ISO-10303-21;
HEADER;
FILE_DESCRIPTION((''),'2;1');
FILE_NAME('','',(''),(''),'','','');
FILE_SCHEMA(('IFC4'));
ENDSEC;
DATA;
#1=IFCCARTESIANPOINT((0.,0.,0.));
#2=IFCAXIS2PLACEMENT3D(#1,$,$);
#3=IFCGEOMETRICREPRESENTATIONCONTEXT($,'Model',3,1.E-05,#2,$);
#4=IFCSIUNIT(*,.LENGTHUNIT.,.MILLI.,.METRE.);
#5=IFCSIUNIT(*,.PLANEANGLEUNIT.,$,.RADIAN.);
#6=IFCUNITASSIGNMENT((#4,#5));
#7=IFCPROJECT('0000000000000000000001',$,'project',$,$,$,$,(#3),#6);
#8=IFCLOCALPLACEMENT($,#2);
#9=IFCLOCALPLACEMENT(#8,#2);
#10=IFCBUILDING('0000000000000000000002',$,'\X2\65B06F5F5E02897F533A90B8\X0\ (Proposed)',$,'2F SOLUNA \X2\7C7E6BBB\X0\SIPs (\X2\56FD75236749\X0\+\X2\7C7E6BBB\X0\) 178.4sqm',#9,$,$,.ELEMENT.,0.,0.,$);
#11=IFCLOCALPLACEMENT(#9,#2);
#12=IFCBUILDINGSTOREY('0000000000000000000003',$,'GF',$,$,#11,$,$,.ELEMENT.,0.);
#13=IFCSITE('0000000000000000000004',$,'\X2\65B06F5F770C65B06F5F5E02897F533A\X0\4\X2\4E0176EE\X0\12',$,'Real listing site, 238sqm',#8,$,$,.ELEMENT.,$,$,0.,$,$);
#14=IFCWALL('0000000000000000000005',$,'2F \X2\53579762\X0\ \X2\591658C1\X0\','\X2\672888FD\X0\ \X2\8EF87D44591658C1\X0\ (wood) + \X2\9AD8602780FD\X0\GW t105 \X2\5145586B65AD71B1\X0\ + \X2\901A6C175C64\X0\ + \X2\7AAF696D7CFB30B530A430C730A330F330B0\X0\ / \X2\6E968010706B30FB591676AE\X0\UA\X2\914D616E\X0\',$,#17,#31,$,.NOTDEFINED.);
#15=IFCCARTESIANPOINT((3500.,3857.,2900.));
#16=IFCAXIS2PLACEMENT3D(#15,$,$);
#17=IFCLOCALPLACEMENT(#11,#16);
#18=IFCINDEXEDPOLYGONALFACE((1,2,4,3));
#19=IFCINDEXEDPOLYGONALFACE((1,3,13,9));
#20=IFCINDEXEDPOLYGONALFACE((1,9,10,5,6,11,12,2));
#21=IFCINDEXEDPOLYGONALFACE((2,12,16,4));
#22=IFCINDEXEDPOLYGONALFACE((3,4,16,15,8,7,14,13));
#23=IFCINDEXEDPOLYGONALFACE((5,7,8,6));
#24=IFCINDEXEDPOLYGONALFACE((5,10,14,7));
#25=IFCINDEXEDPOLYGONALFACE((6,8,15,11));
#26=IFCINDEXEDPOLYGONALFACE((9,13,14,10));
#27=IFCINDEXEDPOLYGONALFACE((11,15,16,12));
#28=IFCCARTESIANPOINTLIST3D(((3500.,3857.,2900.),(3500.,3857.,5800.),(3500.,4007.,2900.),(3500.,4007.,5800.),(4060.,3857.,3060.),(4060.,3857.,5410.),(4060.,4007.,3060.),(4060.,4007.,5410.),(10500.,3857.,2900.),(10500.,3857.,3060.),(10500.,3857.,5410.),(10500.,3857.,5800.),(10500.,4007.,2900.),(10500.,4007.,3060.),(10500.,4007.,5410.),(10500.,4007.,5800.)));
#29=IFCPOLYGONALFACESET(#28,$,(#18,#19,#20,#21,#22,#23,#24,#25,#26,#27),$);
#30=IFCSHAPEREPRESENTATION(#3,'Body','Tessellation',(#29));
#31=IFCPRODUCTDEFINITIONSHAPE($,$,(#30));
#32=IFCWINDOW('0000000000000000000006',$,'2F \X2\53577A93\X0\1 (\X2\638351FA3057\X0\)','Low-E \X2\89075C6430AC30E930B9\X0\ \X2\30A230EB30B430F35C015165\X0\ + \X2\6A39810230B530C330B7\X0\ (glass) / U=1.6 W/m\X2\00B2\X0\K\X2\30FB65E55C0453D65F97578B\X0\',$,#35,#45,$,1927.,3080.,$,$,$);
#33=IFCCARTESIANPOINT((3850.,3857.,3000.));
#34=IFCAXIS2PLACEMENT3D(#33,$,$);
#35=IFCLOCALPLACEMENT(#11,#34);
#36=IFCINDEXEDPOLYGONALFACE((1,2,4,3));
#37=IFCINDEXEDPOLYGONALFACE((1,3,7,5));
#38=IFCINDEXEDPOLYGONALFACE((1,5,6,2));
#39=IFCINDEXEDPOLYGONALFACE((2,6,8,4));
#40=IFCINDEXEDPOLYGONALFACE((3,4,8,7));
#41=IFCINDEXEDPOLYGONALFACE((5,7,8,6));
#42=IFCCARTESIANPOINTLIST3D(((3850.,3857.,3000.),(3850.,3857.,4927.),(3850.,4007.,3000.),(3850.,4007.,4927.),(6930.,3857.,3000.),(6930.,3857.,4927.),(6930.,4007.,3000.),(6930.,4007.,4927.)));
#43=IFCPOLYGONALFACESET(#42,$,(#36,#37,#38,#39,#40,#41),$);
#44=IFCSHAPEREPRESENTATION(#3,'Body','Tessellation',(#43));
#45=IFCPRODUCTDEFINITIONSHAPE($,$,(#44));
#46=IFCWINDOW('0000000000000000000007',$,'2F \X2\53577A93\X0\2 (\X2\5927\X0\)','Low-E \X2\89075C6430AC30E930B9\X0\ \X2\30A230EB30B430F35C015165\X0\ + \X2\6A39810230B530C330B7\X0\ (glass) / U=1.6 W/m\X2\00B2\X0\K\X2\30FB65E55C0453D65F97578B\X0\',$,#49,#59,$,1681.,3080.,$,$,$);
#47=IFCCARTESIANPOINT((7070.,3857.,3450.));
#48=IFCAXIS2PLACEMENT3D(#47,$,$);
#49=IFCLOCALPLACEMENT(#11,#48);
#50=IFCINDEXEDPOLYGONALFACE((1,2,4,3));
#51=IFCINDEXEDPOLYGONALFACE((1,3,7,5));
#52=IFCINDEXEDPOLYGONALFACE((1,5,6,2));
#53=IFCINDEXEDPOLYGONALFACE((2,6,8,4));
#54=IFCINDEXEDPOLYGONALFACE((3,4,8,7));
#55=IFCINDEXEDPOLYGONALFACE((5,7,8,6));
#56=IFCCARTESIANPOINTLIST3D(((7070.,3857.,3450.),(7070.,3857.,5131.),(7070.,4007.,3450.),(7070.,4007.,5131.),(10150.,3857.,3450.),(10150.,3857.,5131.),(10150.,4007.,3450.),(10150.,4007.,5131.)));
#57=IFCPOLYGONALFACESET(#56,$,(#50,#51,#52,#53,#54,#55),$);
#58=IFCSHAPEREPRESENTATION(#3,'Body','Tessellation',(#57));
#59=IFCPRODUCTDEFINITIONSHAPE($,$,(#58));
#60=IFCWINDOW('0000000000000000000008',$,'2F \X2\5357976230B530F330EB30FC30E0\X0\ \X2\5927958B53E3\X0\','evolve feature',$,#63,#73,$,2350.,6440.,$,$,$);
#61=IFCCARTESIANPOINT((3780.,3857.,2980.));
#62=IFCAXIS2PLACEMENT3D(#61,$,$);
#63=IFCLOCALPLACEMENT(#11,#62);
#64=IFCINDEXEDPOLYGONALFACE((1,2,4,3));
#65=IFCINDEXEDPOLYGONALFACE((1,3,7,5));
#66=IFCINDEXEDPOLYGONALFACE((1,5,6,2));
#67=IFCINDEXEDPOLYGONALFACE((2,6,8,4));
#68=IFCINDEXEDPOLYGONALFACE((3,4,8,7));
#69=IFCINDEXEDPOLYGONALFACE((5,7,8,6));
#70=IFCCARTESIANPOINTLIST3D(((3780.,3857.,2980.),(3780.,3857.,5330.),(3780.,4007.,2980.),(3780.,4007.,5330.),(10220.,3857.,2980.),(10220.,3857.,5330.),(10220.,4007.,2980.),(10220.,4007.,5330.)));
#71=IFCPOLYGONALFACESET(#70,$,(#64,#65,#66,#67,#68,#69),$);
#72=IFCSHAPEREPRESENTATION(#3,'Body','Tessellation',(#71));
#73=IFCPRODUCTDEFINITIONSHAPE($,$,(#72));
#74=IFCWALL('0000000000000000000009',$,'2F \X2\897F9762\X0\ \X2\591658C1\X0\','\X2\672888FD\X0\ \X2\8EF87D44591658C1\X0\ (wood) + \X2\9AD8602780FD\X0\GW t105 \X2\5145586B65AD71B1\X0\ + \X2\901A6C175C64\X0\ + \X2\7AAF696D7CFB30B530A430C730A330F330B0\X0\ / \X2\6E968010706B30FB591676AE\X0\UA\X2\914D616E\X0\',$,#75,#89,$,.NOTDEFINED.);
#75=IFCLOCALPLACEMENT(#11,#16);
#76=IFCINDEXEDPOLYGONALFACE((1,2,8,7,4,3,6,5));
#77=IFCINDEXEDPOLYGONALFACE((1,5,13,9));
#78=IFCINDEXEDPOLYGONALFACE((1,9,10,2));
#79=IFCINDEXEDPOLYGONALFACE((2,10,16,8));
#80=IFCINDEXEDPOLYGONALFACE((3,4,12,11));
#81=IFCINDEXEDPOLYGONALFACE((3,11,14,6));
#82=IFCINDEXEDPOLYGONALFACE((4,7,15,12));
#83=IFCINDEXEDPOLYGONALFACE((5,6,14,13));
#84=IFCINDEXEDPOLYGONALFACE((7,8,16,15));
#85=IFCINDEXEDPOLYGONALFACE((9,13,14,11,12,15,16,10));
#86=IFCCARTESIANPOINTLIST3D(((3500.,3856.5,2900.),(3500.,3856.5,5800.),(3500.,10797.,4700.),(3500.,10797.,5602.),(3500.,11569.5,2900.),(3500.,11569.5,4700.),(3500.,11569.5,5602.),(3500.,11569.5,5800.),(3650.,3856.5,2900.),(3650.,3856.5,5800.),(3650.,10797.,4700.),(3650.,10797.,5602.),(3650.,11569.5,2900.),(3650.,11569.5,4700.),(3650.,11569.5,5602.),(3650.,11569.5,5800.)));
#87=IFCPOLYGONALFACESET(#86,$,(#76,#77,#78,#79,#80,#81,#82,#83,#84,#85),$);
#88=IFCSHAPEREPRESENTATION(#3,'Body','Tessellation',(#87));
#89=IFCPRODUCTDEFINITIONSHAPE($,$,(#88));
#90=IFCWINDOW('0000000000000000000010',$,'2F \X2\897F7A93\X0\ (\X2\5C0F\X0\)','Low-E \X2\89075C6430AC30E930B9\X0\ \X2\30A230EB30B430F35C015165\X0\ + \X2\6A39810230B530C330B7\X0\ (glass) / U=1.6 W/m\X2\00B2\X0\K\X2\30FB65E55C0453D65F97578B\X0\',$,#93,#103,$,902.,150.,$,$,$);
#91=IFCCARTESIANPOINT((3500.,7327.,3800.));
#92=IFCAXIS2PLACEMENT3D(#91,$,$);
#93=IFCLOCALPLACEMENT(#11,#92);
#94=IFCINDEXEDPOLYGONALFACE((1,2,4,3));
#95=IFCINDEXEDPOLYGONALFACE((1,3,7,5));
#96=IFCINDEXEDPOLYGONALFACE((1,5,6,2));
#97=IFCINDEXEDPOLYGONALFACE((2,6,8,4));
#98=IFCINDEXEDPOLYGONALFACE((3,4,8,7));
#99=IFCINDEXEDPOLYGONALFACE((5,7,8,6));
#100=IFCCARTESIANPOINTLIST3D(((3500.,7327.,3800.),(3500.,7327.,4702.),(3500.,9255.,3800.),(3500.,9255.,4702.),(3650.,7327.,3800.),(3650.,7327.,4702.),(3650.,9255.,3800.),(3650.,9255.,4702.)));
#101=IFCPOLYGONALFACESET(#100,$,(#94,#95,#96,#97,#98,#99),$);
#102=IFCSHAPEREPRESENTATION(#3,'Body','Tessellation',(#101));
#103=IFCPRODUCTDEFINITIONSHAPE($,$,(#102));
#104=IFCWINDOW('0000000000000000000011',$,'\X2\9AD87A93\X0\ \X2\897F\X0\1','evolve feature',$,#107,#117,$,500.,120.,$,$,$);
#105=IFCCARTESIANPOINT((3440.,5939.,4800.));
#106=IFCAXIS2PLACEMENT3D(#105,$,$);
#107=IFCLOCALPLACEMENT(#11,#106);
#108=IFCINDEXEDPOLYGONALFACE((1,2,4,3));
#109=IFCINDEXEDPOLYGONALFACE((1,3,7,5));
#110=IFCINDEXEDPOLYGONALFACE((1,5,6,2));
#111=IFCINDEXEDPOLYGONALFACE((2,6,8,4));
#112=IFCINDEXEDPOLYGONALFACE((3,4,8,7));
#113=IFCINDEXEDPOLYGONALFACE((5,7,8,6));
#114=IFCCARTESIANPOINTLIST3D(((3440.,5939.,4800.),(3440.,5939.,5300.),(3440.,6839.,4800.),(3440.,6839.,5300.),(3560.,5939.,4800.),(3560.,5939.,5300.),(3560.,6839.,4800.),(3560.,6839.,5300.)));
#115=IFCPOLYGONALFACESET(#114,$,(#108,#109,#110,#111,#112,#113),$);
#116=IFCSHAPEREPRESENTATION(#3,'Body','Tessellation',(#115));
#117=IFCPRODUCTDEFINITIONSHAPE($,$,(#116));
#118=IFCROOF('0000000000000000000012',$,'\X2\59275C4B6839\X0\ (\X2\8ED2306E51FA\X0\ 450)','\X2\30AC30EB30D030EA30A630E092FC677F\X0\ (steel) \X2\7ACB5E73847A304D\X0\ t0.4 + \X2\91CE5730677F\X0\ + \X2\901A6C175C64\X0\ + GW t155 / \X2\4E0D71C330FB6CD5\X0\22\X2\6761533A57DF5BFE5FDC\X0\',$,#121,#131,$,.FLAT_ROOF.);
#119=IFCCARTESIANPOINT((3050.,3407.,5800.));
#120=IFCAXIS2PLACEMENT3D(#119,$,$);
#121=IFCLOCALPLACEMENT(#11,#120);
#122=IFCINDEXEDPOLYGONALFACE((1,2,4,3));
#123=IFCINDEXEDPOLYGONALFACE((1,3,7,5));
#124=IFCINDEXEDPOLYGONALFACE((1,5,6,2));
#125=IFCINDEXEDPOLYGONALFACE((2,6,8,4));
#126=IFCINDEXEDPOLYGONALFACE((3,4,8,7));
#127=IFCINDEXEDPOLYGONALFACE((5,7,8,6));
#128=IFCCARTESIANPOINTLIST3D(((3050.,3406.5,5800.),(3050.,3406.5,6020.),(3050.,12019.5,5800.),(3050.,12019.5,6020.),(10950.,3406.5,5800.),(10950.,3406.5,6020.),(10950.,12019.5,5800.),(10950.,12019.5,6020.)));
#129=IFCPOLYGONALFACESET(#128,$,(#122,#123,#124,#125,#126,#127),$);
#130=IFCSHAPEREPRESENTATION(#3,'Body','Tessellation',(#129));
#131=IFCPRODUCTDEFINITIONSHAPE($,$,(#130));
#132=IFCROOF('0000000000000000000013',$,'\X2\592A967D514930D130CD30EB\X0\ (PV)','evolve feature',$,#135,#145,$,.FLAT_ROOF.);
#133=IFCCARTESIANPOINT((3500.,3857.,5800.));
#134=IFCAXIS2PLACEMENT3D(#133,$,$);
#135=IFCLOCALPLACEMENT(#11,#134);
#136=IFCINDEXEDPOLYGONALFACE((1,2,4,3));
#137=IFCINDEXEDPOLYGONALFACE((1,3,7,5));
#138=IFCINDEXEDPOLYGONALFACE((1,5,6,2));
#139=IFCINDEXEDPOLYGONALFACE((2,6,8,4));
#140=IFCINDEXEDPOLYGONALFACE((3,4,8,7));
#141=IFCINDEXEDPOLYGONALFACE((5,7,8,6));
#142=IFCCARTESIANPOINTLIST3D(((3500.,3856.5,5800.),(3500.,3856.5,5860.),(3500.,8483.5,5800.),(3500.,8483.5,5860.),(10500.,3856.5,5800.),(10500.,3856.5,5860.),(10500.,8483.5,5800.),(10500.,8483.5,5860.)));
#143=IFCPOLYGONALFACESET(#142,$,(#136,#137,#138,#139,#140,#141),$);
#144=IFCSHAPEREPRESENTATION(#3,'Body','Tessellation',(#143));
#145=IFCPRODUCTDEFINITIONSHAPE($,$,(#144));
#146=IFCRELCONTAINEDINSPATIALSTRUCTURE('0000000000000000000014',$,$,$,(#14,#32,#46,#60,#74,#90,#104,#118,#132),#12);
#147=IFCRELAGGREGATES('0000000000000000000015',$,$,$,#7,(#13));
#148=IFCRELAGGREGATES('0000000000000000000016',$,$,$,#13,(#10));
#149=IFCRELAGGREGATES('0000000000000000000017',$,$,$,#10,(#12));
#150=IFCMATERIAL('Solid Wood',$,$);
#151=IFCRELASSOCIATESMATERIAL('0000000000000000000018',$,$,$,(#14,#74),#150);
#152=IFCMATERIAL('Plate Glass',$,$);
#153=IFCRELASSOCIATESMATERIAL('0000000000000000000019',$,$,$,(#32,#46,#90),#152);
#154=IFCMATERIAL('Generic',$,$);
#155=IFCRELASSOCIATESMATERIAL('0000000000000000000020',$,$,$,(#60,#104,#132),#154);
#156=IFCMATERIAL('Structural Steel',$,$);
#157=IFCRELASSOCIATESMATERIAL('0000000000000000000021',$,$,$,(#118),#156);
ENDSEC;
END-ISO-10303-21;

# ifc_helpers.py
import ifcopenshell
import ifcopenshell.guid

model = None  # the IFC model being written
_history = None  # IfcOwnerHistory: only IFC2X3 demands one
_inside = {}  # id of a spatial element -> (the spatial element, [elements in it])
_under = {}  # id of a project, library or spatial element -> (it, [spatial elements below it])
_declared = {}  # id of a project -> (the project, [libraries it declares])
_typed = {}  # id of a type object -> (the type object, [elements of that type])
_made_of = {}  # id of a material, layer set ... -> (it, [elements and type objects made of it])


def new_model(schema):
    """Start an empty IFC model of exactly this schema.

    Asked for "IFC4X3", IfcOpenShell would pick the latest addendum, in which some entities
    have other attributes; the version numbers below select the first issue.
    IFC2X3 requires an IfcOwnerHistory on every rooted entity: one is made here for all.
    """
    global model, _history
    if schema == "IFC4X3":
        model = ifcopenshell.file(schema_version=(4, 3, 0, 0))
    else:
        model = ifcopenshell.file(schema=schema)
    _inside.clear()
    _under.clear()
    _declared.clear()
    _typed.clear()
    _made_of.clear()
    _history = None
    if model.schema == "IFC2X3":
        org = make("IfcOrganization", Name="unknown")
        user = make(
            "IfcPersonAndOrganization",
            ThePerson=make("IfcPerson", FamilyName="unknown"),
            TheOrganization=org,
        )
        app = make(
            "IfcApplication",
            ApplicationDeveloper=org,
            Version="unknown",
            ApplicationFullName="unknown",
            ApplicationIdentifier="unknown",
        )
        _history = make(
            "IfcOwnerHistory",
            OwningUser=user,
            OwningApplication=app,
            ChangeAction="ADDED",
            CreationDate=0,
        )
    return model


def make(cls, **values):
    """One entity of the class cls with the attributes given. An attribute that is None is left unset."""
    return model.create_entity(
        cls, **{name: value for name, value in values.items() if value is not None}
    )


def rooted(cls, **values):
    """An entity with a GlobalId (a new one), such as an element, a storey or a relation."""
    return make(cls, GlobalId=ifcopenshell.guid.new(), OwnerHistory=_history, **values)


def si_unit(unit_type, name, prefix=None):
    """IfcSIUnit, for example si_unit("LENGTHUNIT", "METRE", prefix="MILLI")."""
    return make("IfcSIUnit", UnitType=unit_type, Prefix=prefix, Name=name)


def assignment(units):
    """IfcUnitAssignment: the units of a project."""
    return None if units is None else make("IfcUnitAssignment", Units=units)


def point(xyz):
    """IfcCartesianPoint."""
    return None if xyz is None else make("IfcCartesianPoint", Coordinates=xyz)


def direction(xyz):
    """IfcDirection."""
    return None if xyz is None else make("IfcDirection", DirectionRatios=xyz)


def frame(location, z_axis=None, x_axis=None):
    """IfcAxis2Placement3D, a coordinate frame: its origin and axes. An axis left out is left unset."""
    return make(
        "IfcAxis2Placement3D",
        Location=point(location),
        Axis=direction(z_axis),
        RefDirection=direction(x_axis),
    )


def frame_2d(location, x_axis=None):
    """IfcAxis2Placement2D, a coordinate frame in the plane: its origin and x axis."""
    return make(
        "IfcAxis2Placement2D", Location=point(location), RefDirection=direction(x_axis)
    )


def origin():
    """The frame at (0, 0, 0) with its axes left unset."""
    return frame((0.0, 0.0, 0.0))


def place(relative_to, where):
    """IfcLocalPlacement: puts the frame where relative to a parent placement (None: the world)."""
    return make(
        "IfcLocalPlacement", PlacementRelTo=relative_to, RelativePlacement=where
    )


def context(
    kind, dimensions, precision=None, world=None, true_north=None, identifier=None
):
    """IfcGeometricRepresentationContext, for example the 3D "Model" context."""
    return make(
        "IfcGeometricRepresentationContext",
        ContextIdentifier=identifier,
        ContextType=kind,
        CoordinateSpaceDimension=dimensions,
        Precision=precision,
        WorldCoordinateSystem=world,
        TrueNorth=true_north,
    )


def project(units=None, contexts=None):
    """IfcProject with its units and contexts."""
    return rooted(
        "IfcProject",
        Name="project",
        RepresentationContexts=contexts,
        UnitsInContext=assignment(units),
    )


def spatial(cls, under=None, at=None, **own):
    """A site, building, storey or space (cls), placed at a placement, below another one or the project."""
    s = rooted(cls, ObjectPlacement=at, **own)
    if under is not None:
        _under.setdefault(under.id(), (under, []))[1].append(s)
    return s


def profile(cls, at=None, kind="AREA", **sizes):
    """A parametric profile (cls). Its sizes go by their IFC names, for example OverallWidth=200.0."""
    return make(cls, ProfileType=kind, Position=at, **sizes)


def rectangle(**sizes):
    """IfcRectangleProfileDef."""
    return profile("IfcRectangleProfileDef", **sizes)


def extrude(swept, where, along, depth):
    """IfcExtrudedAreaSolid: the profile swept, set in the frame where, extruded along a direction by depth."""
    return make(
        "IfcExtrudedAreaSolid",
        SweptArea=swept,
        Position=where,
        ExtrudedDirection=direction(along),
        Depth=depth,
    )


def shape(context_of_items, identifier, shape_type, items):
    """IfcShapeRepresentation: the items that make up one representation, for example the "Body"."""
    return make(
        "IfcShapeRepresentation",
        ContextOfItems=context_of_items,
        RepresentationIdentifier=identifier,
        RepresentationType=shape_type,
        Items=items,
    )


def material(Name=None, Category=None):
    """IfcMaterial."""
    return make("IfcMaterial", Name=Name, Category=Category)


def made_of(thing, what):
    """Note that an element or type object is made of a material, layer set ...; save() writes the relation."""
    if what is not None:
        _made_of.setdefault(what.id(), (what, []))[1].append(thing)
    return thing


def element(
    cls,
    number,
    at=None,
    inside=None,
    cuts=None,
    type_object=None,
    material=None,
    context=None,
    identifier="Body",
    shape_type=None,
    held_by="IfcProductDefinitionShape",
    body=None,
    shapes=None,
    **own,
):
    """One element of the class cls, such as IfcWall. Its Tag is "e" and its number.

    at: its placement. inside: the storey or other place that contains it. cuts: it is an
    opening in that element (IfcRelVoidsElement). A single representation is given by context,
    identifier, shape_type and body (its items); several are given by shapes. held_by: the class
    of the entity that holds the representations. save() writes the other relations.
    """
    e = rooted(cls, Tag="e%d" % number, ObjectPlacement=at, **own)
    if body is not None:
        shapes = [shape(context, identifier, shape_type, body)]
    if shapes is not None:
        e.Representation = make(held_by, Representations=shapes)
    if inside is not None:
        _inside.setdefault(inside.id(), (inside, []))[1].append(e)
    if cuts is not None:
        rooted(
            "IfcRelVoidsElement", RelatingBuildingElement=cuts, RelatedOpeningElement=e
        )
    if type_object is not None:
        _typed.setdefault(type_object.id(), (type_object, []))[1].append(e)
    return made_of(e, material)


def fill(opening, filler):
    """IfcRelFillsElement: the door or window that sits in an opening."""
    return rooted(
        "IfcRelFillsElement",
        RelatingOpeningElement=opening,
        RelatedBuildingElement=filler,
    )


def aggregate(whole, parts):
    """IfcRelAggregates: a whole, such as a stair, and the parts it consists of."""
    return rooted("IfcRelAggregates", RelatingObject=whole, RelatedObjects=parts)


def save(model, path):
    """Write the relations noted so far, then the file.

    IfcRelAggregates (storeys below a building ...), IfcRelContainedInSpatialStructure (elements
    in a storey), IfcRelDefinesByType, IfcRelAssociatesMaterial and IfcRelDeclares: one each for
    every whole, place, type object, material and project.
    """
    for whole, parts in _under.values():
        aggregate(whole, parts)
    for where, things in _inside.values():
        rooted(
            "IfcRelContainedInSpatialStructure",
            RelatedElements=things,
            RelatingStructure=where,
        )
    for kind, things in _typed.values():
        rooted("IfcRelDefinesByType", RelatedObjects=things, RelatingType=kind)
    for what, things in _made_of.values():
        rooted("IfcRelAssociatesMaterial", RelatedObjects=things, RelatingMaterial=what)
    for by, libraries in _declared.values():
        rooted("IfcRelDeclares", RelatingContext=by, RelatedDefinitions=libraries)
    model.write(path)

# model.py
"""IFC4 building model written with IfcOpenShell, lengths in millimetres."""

from ifc_helpers import new_model, si_unit, frame, frame_2d, origin, place, context, project, spatial, rectangle, extrude, material, element, fill, save


model = new_model("IFC4")

# Units and contexts
model_context = context("Model", 3, precision=1e-05, world=origin())
ifc_project = project(units=[si_unit("LENGTHUNIT", "METRE", prefix="MILLI"), si_unit("PLANEANGLEUNIT", "RADIAN")], contexts=[model_context])

# Site, building, storey
site_placement = place(None, origin())
site = spatial("IfcSite", under=ifc_project, at=site_placement, Name="新潟県新潟市西区4丁目12", ObjectType="Real listing site, 238sqm", CompositionType="ELEMENT", RefElevation=0.0)
building_placement = place(site_placement, origin())
building = spatial("IfcBuilding", under=site, at=building_placement, Name="新潟市西区邸 (Proposed)", ObjectType="2F SOLUNA 籾殻SIPs (国産杉+籾殻) 178.4sqm", CompositionType="ELEMENT", ElevationOfRefHeight=0.0, ElevationOfTerrain=0.0)
storey_placement = place(building_placement, origin())
storey = spatial("IfcBuildingStorey", under=building, at=storey_placement, Name="GF", CompositionType="ELEMENT", Elevation=0.0)

# Shared definitions
ifc_material_1 = material(Name="Solid Wood")
ifc_material_2 = material(Name="Generic")

# Shared definitions
ifc_material_3 = material(Name="Plate Glass")

# Walls, openings, windows
wall_1_placement = place(storey_placement, frame((3500.0, 3857.0, 2900.0)))
wall_1 = element("IfcWall", 1, at=wall_1_placement, inside=storey, material=ifc_material_1, Name="2F 南面 外壁", Description="木製 軸組外壁 (wood) + 高性能GW t105 充填断熱 + 通気層 + 窯業系サイディング / 準耐火・外皮UA配慮", PredefinedType="NOTDEFINED", context=model_context, shape_type="SweptSolid", body=[
    extrude(rectangle(XDim=7000.0, YDim=150.0, at=frame_2d((3500.0, 75.0))), frame((3500.0, 3857.0, 2900.0)), (0.0, 0.0, 1.0), 2900.0),
])
opening_1_placement = place(storey_placement, frame((3850.0, 3857.0, 3000.0)))
opening_1 = element("IfcOpeningElement", 2, at=opening_1_placement, cuts=wall_1, PredefinedType="NOTDEFINED", context=model_context, shape_type="SweptSolid", body=[
    extrude(rectangle(XDim=3080.0, YDim=150.0, at=frame_2d((1540.0, 75.0))), frame((3850.0, 3857.0, 3000.0)), (0.0, 0.0, 1.0), 1927.0),
])
opening_2_placement = place(storey_placement, frame((7070.0, 3857.0, 3450.0)))
opening_2 = element("IfcOpeningElement", 3, at=opening_2_placement, cuts=wall_1, PredefinedType="NOTDEFINED", context=model_context, shape_type="SweptSolid", body=[
    extrude(rectangle(XDim=3080.0, YDim=150.0, at=frame_2d((1540.0, 75.0))), frame((7070.0, 3857.0, 3450.0)), (0.0, 0.0, 1.0), 1681.0),
])
opening_3_placement = place(storey_placement, frame((3780.0, 3857.0, 2980.0)))
opening_3 = element("IfcOpeningElement", 4, at=opening_3_placement, cuts=wall_1, PredefinedType="NOTDEFINED", context=model_context, shape_type="SweptSolid", body=[
    extrude(rectangle(XDim=6440.0, YDim=150.0, at=frame_2d((3220.0, 75.0))), frame((3780.0, 3857.0, 2980.0)), (0.0, 0.0, 1.0), 2350.0),
])
window_1_placement = place(storey_placement, frame((3850.0, 3857.0, 3000.0)))
window_1 = element("IfcWindow", 5, at=window_1_placement, inside=storey, material=ifc_material_3, Name="2F 南窓1 (掃出し)", Description="Low-E 複層ガラス アルゴン封入 + 樹脂サッシ (glass) / U=1.6 W/m²K・日射取得型", OverallHeight=1927.0, OverallWidth=3080.0, context=model_context, shape_type="SweptSolid", body=[
    extrude(rectangle(XDim=3080.0, YDim=150.0, at=frame_2d((1540.0, 75.0))), frame((3850.0, 3857.0, 3000.0)), (0.0, 0.0, 1.0), 1927.0),
])
fill(opening_1, window_1)
window_2_placement = place(storey_placement, frame((7070.0, 3857.0, 3450.0)))
window_2 = element("IfcWindow", 6, at=window_2_placement, inside=storey, material=ifc_material_3, Name="2F 南窓2 (大)", Description="Low-E 複層ガラス アルゴン封入 + 樹脂サッシ (glass) / U=1.6 W/m²K・日射取得型", OverallHeight=1681.0, OverallWidth=3080.0, context=model_context, shape_type="SweptSolid", body=[
    extrude(rectangle(XDim=3080.0, YDim=150.0, at=frame_2d((1540.0, 75.0))), frame((7070.0, 3857.0, 3450.0)), (0.0, 0.0, 1.0), 1681.0),
])
fill(opening_2, window_2)
window_3_placement = place(storey_placement, frame((3780.0, 3857.0, 2980.0)))
window_3 = element("IfcWindow", 7, at=window_3_placement, inside=storey, material=ifc_material_2, Name="2F 南面サンルーム 大開口", Description="evolve feature", OverallHeight=2350.0, OverallWidth=6440.0, context=model_context, shape_type="SweptSolid", body=[
    extrude(rectangle(XDim=6440.0, YDim=150.0, at=frame_2d((3220.0, 75.0))), frame((3780.0, 3857.0, 2980.0)), (0.0, 0.0, 1.0), 2350.0),
])
fill(opening_3, window_3)
wall_2_placement = place(storey_placement, frame((3500.0, 3857.0, 2900.0)))
wall_2 = element("IfcWall", 8, at=wall_2_placement, inside=storey, material=ifc_material_1, Name="2F 西面 外壁", Description="木製 軸組外壁 (wood) + 高性能GW t105 充填断熱 + 通気層 + 窯業系サイディング / 準耐火・外皮UA配慮", PredefinedType="NOTDEFINED", context=model_context, shape_type="SweptSolid", body=[
    extrude(rectangle(XDim=150.0, YDim=7713.0, at=frame_2d((75.0, 3856.0))), frame((3500.0, 3857.0, 2900.0)), (0.0, 0.0, 1.0), 2900.0),
])
opening_4_placement = place(storey_placement, frame((3500.0, 7327.0, 3800.0)))
opening_4 = element("IfcOpeningElement", 9, at=opening_4_placement, cuts=wall_2, PredefinedType="NOTDEFINED", context=model_context, shape_type="SweptSolid", body=[
    extrude(rectangle(XDim=150.0, YDim=1928.0, at=frame_2d((75.0, 964.0))), frame((3500.0, 7327.0, 3800.0)), (0.0, 0.0, 1.0), 902.0),
])
opening_5_placement = place(storey_placement, frame((3440.0, 5939.0, 4800.0)))
opening_5 = element("IfcOpeningElement", 10, at=opening_5_placement, cuts=wall_2, PredefinedType="NOTDEFINED", context=model_context, shape_type="SweptSolid", body=[
    extrude(rectangle(XDim=120.0, YDim=900.0, at=frame_2d((60.0, 450.0))), frame((3440.0, 5939.0, 4800.0)), (0.0, 0.0, 1.0), 500.0),
])
window_4_placement = place(storey_placement, frame((3500.0, 7327.0, 3800.0)))
window_4 = element("IfcWindow", 11, at=window_4_placement, inside=storey, material=ifc_material_3, Name="2F 西窓 (小)", Description="Low-E 複層ガラス アルゴン封入 + 樹脂サッシ (glass) / U=1.6 W/m²K・日射取得型", OverallHeight=902.0, OverallWidth=150.0, context=model_context, shape_type="SweptSolid", body=[
    extrude(rectangle(XDim=150.0, YDim=1928.0, at=frame_2d((75.0, 964.0))), frame((3500.0, 7327.0, 3800.0)), (0.0, 0.0, 1.0), 902.0),
])
fill(opening_4, window_4)
window_5_placement = place(storey_placement, frame((3440.0, 5939.0, 4800.0)))
window_5 = element("IfcWindow", 12, at=window_5_placement, inside=storey, material=ifc_material_2, Name="高窓 西1", Description="evolve feature", OverallHeight=500.0, OverallWidth=120.0, context=model_context, shape_type="SweptSolid", body=[
    extrude(rectangle(XDim=120.0, YDim=900.0, at=frame_2d((60.0, 450.0))), frame((3440.0, 5939.0, 4800.0)), (0.0, 0.0, 1.0), 500.0),
])
fill(opening_5, window_5)

# Roofs
ifc_material_4 = material(Name="Structural Steel")
roof_1_placement = place(storey_placement, frame((3050.0, 3407.0, 5800.0)))
element("IfcRoof", 13, at=roof_1_placement, inside=storey, material=ifc_material_4, Name="大屋根 (軒の出 450)", Description="ガルバリウム鋼板 (steel) 立平葺き t0.4 + 野地板 + 通気層 + GW t155 / 不燃・法22条区域対応", PredefinedType="FLAT_ROOF", context=model_context, shape_type="SweptSolid", body=[
    extrude(rectangle(XDim=7900.0, YDim=8613.0, at=frame_2d((3950.0, 4306.0))), frame((3050.0, 3407.0, 5800.0)), (0.0, 0.0, 1.0), 220.0),
])
roof_2_placement = place(storey_placement, frame((3500.0, 3857.0, 5800.0)))
element("IfcRoof", 14, at=roof_2_placement, inside=storey, material=ifc_material_2, Name="太陽光パネル (PV)", Description="evolve feature", PredefinedType="FLAT_ROOF", context=model_context, shape_type="SweptSolid", body=[
    extrude(rectangle(XDim=7000.0, YDim=4627.0, at=frame_2d((3500.0, 2313.0))), frame((3500.0, 3857.0, 5800.0)), (0.0, 0.0, 1.0), 60.0),
])

save(model, "model.ifc")
